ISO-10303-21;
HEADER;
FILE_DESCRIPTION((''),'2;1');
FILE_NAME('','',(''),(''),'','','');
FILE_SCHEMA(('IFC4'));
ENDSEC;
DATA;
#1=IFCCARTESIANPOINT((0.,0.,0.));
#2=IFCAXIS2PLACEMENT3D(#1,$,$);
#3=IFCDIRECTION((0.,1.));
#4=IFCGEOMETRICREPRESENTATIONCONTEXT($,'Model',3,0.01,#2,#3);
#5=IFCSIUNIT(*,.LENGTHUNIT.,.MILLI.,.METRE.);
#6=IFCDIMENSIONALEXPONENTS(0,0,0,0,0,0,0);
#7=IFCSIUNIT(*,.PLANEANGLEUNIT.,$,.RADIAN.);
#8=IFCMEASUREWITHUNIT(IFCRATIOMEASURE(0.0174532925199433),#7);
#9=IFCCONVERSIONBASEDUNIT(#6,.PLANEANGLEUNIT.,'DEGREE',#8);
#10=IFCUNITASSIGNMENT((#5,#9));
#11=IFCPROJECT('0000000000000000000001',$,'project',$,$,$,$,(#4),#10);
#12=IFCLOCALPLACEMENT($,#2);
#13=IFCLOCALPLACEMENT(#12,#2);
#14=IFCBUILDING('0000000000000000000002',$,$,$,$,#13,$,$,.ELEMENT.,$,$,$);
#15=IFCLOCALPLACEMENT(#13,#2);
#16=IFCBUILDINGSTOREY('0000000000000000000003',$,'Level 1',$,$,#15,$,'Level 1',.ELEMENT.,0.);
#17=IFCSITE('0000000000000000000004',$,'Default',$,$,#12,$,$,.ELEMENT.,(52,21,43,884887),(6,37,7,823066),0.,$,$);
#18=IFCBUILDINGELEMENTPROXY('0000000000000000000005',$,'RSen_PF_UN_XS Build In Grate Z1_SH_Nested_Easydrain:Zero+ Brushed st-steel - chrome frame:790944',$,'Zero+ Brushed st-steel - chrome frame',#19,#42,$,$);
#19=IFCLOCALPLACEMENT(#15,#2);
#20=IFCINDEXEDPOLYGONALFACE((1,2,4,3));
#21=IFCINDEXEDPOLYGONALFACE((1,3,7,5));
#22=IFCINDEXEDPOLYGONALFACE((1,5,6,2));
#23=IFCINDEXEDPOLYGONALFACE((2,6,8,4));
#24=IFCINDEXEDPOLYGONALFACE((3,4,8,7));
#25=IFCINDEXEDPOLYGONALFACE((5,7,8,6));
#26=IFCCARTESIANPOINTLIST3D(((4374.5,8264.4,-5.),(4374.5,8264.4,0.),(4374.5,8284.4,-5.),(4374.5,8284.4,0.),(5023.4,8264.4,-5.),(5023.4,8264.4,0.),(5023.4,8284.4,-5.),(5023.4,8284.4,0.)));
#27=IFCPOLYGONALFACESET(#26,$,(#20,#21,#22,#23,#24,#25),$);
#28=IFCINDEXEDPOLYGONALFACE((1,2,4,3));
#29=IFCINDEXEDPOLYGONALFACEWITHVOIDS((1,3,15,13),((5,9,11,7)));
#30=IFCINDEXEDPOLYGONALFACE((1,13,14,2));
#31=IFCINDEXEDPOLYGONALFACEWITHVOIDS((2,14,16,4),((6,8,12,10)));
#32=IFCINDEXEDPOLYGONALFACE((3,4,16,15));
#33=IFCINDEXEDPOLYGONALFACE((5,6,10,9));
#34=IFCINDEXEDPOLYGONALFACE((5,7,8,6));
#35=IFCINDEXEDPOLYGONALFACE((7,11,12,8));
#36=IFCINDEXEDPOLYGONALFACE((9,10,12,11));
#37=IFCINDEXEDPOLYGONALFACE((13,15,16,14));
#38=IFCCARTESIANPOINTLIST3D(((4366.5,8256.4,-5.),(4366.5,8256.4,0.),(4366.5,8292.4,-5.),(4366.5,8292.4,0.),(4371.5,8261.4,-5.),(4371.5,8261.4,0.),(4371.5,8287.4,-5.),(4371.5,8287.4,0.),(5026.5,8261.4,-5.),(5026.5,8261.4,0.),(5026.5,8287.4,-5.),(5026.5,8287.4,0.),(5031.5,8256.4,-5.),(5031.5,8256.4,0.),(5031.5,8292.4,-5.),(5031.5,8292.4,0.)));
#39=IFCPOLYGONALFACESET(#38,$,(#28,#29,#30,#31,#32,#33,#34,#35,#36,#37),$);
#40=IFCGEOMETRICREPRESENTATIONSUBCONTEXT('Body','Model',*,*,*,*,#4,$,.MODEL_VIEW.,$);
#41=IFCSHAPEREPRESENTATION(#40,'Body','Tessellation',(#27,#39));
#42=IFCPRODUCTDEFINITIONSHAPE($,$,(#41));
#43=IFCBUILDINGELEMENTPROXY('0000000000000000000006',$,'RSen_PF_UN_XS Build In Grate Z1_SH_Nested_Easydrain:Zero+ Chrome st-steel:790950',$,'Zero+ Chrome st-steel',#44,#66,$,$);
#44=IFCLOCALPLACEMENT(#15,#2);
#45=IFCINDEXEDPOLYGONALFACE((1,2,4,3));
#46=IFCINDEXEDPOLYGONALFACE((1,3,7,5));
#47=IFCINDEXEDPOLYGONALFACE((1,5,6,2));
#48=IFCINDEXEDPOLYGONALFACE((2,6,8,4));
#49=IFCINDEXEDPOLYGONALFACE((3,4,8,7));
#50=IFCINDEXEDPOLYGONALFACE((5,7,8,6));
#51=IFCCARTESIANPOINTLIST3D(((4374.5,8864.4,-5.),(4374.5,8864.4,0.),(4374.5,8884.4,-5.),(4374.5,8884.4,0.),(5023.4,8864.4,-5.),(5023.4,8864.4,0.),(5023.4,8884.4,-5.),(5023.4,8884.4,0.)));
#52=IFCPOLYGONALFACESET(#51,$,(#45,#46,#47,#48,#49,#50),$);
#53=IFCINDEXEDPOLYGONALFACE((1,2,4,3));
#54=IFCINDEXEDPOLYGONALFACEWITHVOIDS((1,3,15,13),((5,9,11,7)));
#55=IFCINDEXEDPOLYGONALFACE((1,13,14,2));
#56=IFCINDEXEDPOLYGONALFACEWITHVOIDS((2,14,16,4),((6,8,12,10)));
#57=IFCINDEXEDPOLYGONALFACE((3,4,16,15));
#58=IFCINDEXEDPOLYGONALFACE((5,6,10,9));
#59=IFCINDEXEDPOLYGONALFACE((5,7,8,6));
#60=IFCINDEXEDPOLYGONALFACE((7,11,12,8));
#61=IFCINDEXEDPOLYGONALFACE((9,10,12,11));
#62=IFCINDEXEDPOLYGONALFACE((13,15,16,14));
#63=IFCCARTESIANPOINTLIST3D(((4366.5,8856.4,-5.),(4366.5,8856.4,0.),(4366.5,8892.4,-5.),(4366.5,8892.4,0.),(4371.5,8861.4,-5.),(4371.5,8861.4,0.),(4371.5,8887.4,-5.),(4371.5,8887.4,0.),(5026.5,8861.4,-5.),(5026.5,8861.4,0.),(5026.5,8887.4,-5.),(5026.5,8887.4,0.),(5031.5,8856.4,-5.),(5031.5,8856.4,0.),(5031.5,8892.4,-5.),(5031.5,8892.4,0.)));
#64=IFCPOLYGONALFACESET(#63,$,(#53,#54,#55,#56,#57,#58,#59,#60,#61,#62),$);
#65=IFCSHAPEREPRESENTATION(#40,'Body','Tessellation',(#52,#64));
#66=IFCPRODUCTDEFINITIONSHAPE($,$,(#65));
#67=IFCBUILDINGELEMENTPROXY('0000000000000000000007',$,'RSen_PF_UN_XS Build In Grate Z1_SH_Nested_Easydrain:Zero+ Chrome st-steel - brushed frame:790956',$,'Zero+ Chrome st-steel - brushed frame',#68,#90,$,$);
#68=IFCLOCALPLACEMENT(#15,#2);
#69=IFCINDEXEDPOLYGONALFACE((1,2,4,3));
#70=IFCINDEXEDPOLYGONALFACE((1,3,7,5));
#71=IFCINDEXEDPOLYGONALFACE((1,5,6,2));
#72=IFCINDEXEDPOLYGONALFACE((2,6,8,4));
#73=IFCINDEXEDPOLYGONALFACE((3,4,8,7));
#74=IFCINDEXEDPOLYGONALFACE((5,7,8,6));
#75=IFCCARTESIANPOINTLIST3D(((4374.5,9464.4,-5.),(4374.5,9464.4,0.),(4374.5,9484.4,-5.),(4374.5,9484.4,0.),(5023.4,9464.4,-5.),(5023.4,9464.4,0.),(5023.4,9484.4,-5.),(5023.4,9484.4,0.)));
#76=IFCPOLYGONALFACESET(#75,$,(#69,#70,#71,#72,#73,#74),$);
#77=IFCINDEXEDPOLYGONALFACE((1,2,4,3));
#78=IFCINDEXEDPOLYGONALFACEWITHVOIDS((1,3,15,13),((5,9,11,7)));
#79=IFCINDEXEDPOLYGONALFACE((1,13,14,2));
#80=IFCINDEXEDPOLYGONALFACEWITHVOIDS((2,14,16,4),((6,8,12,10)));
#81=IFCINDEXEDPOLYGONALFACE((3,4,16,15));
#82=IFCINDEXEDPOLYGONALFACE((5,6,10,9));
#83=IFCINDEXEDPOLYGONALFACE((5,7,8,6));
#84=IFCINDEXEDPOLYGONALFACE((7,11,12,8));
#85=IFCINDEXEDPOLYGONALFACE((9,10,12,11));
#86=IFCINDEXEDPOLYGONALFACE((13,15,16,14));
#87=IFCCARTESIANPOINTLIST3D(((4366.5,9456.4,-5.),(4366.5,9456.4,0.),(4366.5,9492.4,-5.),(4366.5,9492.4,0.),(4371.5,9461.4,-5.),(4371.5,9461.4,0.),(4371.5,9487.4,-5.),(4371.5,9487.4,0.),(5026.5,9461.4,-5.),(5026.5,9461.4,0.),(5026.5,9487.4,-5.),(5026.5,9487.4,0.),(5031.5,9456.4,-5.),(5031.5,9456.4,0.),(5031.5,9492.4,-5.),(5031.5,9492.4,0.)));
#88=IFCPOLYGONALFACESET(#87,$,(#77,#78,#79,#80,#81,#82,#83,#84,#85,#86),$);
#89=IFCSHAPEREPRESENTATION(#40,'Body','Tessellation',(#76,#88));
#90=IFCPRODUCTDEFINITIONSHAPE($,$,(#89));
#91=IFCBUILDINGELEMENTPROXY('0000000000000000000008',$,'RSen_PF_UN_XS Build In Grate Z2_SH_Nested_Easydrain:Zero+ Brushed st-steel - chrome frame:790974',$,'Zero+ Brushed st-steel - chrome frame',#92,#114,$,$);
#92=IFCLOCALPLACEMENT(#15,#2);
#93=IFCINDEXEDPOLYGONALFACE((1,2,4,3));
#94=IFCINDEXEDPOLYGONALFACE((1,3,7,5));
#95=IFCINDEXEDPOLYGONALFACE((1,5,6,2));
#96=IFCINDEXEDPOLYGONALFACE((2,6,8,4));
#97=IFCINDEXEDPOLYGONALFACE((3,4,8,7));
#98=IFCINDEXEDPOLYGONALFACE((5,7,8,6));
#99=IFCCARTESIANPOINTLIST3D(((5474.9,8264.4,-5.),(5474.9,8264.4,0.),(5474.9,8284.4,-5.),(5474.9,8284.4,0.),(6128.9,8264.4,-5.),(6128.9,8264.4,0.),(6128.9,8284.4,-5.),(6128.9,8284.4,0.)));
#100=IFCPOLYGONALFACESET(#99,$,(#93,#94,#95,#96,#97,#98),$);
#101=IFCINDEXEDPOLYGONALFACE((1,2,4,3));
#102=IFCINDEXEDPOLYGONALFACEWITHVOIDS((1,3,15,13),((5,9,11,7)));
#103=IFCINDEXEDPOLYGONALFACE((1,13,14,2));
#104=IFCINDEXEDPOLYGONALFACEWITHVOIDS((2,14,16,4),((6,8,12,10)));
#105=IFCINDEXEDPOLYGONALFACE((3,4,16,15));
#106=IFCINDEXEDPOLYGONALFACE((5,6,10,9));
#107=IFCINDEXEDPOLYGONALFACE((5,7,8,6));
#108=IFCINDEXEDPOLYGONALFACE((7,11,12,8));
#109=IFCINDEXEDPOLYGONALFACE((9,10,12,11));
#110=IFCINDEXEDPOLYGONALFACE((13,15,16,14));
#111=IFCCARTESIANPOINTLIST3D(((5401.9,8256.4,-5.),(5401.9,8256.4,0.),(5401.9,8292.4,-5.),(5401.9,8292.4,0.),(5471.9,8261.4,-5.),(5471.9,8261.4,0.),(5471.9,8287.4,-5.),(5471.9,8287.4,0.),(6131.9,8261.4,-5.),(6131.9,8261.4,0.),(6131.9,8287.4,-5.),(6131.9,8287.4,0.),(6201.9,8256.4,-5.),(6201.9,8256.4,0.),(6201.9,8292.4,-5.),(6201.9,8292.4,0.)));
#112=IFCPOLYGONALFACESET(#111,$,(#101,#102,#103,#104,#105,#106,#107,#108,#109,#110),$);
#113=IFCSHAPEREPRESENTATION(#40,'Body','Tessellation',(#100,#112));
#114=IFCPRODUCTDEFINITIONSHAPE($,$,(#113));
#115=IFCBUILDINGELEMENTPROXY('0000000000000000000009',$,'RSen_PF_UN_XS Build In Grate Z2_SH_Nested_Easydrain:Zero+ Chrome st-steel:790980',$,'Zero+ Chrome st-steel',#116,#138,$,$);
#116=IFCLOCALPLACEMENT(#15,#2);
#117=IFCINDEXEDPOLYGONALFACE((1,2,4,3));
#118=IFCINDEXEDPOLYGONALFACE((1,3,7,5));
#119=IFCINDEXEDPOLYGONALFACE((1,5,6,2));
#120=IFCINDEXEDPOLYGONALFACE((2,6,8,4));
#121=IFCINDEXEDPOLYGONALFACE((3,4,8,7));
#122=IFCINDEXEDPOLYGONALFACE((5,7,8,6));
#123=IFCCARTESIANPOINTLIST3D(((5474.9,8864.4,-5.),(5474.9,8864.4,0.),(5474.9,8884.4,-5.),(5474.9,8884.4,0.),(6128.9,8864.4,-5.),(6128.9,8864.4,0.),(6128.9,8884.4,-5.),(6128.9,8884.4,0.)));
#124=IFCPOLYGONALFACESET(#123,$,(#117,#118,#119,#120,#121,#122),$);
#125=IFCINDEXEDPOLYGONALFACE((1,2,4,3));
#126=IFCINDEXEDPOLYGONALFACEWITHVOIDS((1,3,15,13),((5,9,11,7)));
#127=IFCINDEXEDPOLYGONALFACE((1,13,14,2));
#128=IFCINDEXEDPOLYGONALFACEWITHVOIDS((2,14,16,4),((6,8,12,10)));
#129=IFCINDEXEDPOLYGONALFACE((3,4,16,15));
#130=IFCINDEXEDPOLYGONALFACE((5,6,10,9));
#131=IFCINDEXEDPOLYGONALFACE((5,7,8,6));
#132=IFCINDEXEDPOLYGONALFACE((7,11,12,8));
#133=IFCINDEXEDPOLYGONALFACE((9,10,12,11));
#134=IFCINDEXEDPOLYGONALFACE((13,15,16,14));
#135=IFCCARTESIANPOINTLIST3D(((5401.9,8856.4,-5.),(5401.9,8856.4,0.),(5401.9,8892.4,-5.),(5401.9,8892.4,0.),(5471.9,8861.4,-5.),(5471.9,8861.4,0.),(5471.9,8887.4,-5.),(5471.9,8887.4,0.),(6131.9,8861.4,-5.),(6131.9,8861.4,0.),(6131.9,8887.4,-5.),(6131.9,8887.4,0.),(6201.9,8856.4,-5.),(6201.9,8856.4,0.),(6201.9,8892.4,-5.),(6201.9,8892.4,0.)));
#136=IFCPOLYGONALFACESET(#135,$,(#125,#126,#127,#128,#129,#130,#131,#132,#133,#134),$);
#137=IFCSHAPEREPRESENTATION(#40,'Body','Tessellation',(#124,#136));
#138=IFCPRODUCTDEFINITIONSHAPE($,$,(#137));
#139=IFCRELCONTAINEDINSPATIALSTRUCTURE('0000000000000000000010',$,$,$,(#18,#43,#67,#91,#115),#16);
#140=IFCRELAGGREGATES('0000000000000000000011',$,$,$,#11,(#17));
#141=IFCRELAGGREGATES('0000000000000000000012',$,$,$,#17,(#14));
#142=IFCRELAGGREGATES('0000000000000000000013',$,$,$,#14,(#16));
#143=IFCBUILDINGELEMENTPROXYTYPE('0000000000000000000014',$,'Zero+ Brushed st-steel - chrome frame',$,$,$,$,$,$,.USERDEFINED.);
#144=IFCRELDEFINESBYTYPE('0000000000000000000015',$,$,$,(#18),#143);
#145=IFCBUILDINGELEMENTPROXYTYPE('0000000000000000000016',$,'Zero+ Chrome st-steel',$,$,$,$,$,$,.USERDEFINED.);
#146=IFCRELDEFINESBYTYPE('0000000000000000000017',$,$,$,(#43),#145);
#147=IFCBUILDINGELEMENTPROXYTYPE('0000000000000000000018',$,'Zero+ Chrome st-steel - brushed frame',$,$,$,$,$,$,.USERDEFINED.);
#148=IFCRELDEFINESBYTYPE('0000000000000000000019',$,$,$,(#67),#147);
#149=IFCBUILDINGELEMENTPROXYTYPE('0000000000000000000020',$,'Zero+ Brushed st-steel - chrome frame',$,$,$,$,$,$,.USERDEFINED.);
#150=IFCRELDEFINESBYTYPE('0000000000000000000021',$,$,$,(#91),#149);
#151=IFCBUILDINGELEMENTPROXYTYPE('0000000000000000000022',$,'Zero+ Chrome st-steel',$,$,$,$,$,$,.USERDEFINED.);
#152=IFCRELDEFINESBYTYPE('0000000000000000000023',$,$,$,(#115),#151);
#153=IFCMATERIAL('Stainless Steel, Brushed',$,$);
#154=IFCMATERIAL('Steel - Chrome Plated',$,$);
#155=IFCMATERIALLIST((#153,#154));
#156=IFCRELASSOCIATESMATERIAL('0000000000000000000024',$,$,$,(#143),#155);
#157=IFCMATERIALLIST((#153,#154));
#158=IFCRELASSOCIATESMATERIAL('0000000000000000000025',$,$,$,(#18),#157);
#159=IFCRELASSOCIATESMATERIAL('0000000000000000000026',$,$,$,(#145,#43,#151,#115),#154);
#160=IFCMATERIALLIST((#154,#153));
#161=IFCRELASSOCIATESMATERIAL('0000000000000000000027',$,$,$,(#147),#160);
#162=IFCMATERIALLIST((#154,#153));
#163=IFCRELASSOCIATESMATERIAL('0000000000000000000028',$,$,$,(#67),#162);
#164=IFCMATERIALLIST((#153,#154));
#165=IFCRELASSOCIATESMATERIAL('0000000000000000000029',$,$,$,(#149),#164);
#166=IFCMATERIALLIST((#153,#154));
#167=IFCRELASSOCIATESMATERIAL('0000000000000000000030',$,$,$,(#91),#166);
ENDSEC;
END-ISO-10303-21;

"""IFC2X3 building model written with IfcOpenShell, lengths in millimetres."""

from ifc_helpers import new_model, entity, si_unit, converted_unit, direction, frame, origin, origin_2d_with_axis, place, context, subcontext, project, spatial, polyline, rectangle, outline, extrude, source, transform, mapped, material, material_list, type_object, type_shapes, element, save


model = new_model("IFC2X3")

# Units and contexts
model_context = context("Model", 3, precision=0.01, world=origin(), true_north=direction((0.0, 1.0)))
body_context = subcontext(model_context, "Body", "Model", "MODEL_VIEW")
ifc_project = project(units=[si_unit("LENGTHUNIT", "METRE", prefix="MILLI"), converted_unit("PLANEANGLEUNIT", "DEGREE", entity("IfcRatioMeasure", 0.0174532925199433), si_unit("PLANEANGLEUNIT", "RADIAN"), dimensions=[0, 0, 0, 0, 0, 0, 0])], contexts=[model_context])

# Site, building, storey
site_placement = place(None, origin())
site = spatial("IfcSite", under=ifc_project, at=site_placement, Name="Default", CompositionType="ELEMENT", RefLatitude=(52, 21, 43, 884887), RefLongitude=(6, 37, 7, 823066), RefElevation=0.0)
building_placement = place(site_placement, origin())
building = spatial("IfcBuilding", under=site, at=building_placement, CompositionType="ELEMENT")
storey_placement = place(building_placement, origin())
storey = spatial("IfcBuildingStorey", under=building, at=storey_placement, Name="Level 1", LongName="Level 1", CompositionType="ELEMENT", Elevation=0.0)

# Building element proxies
ifc_material_1 = material(Name="Stainless Steel, Brushed")
ifc_material_2 = material(Name="Steel - Chrome Plated")
ifc_material_list_1 = material_list([ifc_material_1, ifc_material_2])
ifc_material_list_2 = material_list([ifc_material_1, ifc_material_2])
building_element_proxy_type_1 = type_object("IfcBuildingElementProxyType", Name="Zero+ Brushed st-steel - chrome frame", PredefinedType="USERDEFINED", material=ifc_material_list_2)
shared_shape_1 = source(origin(), body_context, "Body", "SweptSolid", [
    extrude(rectangle(XDim=649.0, YDim=20.0, at=origin_2d_with_axis()), frame((0.0, 0.0, 0.0), z_axis=(0.0, 0.0, 1.0), x_axis=(-1.0, 0.0, 0.0)), (0.0, 0.0, 1.0), 5.0),
    extrude(outline(polyline([(-332.5, -18.0), (332.5, -18.0), (332.5, 18.0), (-332.5, 18.0), (-332.5, -18.0)]), holes=[polyline([(-327.5, -13.0), (-327.5, 13.0), (327.5, 13.0), (327.5, -13.0), (-327.5, -13.0)])]), frame((0.0, 0.0, 0.0), z_axis=(0.0, 0.0, 1.0), x_axis=(-1.0, 0.0, 0.0)), (0.0, 0.0, 1.0), 5.0),
])
type_shapes(building_element_proxy_type_1, [shared_shape_1])
proxy_1_placement = place(storey_placement, frame((4699.0, 8274.4, -5.0)))
element("IfcBuildingElementProxy", 1, at=proxy_1_placement, inside=storey, type_object=building_element_proxy_type_1, material=ifc_material_list_1, Name="RSen_PF_UN_XS Build In Grate Z1_SH_Nested_Easydrain:Zero+ Brushed st-steel - chrome frame:790944", ObjectType="Zero+ Brushed st-steel - chrome frame", context=body_context, shape_type="MappedRepresentation", body=[
    mapped(shared_shape_1, transform((0.0, 0.0, 0.0), scale=1.0)),
])
building_element_proxy_type_2 = type_object("IfcBuildingElementProxyType", Name="Zero+ Chrome st-steel", PredefinedType="USERDEFINED", material=ifc_material_2)
shared_shape_2 = source(origin(), body_context, "Body", "SweptSolid", [
    extrude(rectangle(XDim=649.0, YDim=20.0, at=origin_2d_with_axis()), frame((0.0, 0.0, 0.0), z_axis=(0.0, 0.0, 1.0), x_axis=(-1.0, 0.0, 0.0)), (0.0, 0.0, 1.0), 5.0),
    extrude(outline(polyline([(-332.5, -18.0), (332.5, -18.0), (332.5, 18.0), (-332.5, 18.0), (-332.5, -18.0)]), holes=[polyline([(-327.5, -13.0), (-327.5, 13.0), (327.5, 13.0), (327.5, -13.0), (-327.5, -13.0)])]), frame((0.0, 0.0, 0.0), z_axis=(0.0, 0.0, 1.0), x_axis=(-1.0, 0.0, 0.0)), (0.0, 0.0, 1.0), 5.0),
])
type_shapes(building_element_proxy_type_2, [shared_shape_2])
proxy_2_placement = place(storey_placement, frame((4699.0, 8874.4, -5.0)))
element("IfcBuildingElementProxy", 2, at=proxy_2_placement, inside=storey, type_object=building_element_proxy_type_2, material=ifc_material_2, Name="RSen_PF_UN_XS Build In Grate Z1_SH_Nested_Easydrain:Zero+ Chrome st-steel:790950", ObjectType="Zero+ Chrome st-steel", context=body_context, shape_type="MappedRepresentation", body=[
    mapped(shared_shape_2, transform((0.0, 0.0, 0.0), scale=1.0)),
])
ifc_material_list_3 = material_list([ifc_material_2, ifc_material_1])
ifc_material_list_4 = material_list([ifc_material_2, ifc_material_1])
building_element_proxy_type_3 = type_object("IfcBuildingElementProxyType", Name="Zero+ Chrome st-steel - brushed frame", PredefinedType="USERDEFINED", material=ifc_material_list_4)
shared_shape_3 = source(origin(), body_context, "Body", "SweptSolid", [
    extrude(rectangle(XDim=649.0, YDim=20.0, at=origin_2d_with_axis()), frame((0.0, 0.0, 0.0), z_axis=(0.0, 0.0, 1.0), x_axis=(-1.0, 0.0, 0.0)), (0.0, 0.0, 1.0), 5.0),
    extrude(outline(polyline([(-332.5, -18.0), (332.5, -18.0), (332.5, 18.0), (-332.5, 18.0), (-332.5, -18.0)]), holes=[polyline([(-327.5, -13.0), (-327.5, 13.0), (327.5, 13.0), (327.5, -13.0), (-327.5, -13.0)])]), frame((0.0, 0.0, 0.0), z_axis=(0.0, 0.0, 1.0), x_axis=(-1.0, 0.0, 0.0)), (0.0, 0.0, 1.0), 5.0),
])
type_shapes(building_element_proxy_type_3, [shared_shape_3])
proxy_3_placement = place(storey_placement, frame((4699.0, 9474.4, -5.0)))
element("IfcBuildingElementProxy", 3, at=proxy_3_placement, inside=storey, type_object=building_element_proxy_type_3, material=ifc_material_list_3, Name="RSen_PF_UN_XS Build In Grate Z1_SH_Nested_Easydrain:Zero+ Chrome st-steel - brushed frame:790956", ObjectType="Zero+ Chrome st-steel - brushed frame", context=body_context, shape_type="MappedRepresentation", body=[
    mapped(shared_shape_3, transform((0.0, 0.0, 0.0), scale=1.0)),
])
ifc_material_list_5 = material_list([ifc_material_1, ifc_material_2])
ifc_material_list_6 = material_list([ifc_material_1, ifc_material_2])
building_element_proxy_type_4 = type_object("IfcBuildingElementProxyType", Name="Zero+ Brushed st-steel - chrome frame", PredefinedType="USERDEFINED", material=ifc_material_list_6)
shared_shape_4 = source(origin(), body_context, "Body", "SweptSolid", [
    extrude(rectangle(XDim=654.0, YDim=20.0, at=origin_2d_with_axis()), frame((0.0, 0.0, 0.0), z_axis=(0.0, 0.0, 1.0), x_axis=(-1.0, 0.0, 0.0)), (0.0, 0.0, 1.0), 5.0),
    extrude(outline(polyline([(-400.0, -18.0), (400.0, -18.0), (400.0, 18.0), (-400.0, 18.0), (-400.0, -18.0)]), holes=[polyline([(-330.0, -13.0), (-330.0, 13.0), (330.0, 13.0), (330.0, -13.0), (-330.0, -13.0)])]), frame((0.0, 0.0, 0.0), z_axis=(0.0, 0.0, 1.0), x_axis=(-1.0, 0.0, 0.0)), (0.0, 0.0, 1.0), 5.0),
])
type_shapes(building_element_proxy_type_4, [shared_shape_4])
proxy_4_placement = place(storey_placement, frame((5801.9, 8274.4, -5.0)))
element("IfcBuildingElementProxy", 4, at=proxy_4_placement, inside=storey, type_object=building_element_proxy_type_4, material=ifc_material_list_5, Name="RSen_PF_UN_XS Build In Grate Z2_SH_Nested_Easydrain:Zero+ Brushed st-steel - chrome frame:790974", ObjectType="Zero+ Brushed st-steel - chrome frame", context=body_context, shape_type="MappedRepresentation", body=[
    mapped(shared_shape_4, transform((0.0, 0.0, 0.0), scale=1.0)),
])
building_element_proxy_type_5 = type_object("IfcBuildingElementProxyType", Name="Zero+ Chrome st-steel", PredefinedType="USERDEFINED", material=ifc_material_2)
shared_shape_5 = source(origin(), body_context, "Body", "SweptSolid", [
    extrude(rectangle(XDim=654.0, YDim=20.0, at=origin_2d_with_axis()), frame((0.0, 0.0, 0.0), z_axis=(0.0, 0.0, 1.0), x_axis=(-1.0, 0.0, 0.0)), (0.0, 0.0, 1.0), 5.0),
    extrude(outline(polyline([(-400.0, -18.0), (400.0, -18.0), (400.0, 18.0), (-400.0, 18.0), (-400.0, -18.0)]), holes=[polyline([(-330.0, -13.0), (-330.0, 13.0), (330.0, 13.0), (330.0, -13.0), (-330.0, -13.0)])]), frame((0.0, 0.0, 0.0), z_axis=(0.0, 0.0, 1.0), x_axis=(-1.0, 0.0, 0.0)), (0.0, 0.0, 1.0), 5.0),
])
type_shapes(building_element_proxy_type_5, [shared_shape_5])
proxy_5_placement = place(storey_placement, frame((5801.9, 8874.4, -5.0)))
element("IfcBuildingElementProxy", 5, at=proxy_5_placement, inside=storey, type_object=building_element_proxy_type_5, material=ifc_material_2, Name="RSen_PF_UN_XS Build In Grate Z2_SH_Nested_Easydrain:Zero+ Chrome st-steel:790980", ObjectType="Zero+ Chrome st-steel", context=body_context, shape_type="MappedRepresentation", body=[
    mapped(shared_shape_5, transform((0.0, 0.0, 0.0), scale=1.0)),
])

save(model, "model.ifc")
